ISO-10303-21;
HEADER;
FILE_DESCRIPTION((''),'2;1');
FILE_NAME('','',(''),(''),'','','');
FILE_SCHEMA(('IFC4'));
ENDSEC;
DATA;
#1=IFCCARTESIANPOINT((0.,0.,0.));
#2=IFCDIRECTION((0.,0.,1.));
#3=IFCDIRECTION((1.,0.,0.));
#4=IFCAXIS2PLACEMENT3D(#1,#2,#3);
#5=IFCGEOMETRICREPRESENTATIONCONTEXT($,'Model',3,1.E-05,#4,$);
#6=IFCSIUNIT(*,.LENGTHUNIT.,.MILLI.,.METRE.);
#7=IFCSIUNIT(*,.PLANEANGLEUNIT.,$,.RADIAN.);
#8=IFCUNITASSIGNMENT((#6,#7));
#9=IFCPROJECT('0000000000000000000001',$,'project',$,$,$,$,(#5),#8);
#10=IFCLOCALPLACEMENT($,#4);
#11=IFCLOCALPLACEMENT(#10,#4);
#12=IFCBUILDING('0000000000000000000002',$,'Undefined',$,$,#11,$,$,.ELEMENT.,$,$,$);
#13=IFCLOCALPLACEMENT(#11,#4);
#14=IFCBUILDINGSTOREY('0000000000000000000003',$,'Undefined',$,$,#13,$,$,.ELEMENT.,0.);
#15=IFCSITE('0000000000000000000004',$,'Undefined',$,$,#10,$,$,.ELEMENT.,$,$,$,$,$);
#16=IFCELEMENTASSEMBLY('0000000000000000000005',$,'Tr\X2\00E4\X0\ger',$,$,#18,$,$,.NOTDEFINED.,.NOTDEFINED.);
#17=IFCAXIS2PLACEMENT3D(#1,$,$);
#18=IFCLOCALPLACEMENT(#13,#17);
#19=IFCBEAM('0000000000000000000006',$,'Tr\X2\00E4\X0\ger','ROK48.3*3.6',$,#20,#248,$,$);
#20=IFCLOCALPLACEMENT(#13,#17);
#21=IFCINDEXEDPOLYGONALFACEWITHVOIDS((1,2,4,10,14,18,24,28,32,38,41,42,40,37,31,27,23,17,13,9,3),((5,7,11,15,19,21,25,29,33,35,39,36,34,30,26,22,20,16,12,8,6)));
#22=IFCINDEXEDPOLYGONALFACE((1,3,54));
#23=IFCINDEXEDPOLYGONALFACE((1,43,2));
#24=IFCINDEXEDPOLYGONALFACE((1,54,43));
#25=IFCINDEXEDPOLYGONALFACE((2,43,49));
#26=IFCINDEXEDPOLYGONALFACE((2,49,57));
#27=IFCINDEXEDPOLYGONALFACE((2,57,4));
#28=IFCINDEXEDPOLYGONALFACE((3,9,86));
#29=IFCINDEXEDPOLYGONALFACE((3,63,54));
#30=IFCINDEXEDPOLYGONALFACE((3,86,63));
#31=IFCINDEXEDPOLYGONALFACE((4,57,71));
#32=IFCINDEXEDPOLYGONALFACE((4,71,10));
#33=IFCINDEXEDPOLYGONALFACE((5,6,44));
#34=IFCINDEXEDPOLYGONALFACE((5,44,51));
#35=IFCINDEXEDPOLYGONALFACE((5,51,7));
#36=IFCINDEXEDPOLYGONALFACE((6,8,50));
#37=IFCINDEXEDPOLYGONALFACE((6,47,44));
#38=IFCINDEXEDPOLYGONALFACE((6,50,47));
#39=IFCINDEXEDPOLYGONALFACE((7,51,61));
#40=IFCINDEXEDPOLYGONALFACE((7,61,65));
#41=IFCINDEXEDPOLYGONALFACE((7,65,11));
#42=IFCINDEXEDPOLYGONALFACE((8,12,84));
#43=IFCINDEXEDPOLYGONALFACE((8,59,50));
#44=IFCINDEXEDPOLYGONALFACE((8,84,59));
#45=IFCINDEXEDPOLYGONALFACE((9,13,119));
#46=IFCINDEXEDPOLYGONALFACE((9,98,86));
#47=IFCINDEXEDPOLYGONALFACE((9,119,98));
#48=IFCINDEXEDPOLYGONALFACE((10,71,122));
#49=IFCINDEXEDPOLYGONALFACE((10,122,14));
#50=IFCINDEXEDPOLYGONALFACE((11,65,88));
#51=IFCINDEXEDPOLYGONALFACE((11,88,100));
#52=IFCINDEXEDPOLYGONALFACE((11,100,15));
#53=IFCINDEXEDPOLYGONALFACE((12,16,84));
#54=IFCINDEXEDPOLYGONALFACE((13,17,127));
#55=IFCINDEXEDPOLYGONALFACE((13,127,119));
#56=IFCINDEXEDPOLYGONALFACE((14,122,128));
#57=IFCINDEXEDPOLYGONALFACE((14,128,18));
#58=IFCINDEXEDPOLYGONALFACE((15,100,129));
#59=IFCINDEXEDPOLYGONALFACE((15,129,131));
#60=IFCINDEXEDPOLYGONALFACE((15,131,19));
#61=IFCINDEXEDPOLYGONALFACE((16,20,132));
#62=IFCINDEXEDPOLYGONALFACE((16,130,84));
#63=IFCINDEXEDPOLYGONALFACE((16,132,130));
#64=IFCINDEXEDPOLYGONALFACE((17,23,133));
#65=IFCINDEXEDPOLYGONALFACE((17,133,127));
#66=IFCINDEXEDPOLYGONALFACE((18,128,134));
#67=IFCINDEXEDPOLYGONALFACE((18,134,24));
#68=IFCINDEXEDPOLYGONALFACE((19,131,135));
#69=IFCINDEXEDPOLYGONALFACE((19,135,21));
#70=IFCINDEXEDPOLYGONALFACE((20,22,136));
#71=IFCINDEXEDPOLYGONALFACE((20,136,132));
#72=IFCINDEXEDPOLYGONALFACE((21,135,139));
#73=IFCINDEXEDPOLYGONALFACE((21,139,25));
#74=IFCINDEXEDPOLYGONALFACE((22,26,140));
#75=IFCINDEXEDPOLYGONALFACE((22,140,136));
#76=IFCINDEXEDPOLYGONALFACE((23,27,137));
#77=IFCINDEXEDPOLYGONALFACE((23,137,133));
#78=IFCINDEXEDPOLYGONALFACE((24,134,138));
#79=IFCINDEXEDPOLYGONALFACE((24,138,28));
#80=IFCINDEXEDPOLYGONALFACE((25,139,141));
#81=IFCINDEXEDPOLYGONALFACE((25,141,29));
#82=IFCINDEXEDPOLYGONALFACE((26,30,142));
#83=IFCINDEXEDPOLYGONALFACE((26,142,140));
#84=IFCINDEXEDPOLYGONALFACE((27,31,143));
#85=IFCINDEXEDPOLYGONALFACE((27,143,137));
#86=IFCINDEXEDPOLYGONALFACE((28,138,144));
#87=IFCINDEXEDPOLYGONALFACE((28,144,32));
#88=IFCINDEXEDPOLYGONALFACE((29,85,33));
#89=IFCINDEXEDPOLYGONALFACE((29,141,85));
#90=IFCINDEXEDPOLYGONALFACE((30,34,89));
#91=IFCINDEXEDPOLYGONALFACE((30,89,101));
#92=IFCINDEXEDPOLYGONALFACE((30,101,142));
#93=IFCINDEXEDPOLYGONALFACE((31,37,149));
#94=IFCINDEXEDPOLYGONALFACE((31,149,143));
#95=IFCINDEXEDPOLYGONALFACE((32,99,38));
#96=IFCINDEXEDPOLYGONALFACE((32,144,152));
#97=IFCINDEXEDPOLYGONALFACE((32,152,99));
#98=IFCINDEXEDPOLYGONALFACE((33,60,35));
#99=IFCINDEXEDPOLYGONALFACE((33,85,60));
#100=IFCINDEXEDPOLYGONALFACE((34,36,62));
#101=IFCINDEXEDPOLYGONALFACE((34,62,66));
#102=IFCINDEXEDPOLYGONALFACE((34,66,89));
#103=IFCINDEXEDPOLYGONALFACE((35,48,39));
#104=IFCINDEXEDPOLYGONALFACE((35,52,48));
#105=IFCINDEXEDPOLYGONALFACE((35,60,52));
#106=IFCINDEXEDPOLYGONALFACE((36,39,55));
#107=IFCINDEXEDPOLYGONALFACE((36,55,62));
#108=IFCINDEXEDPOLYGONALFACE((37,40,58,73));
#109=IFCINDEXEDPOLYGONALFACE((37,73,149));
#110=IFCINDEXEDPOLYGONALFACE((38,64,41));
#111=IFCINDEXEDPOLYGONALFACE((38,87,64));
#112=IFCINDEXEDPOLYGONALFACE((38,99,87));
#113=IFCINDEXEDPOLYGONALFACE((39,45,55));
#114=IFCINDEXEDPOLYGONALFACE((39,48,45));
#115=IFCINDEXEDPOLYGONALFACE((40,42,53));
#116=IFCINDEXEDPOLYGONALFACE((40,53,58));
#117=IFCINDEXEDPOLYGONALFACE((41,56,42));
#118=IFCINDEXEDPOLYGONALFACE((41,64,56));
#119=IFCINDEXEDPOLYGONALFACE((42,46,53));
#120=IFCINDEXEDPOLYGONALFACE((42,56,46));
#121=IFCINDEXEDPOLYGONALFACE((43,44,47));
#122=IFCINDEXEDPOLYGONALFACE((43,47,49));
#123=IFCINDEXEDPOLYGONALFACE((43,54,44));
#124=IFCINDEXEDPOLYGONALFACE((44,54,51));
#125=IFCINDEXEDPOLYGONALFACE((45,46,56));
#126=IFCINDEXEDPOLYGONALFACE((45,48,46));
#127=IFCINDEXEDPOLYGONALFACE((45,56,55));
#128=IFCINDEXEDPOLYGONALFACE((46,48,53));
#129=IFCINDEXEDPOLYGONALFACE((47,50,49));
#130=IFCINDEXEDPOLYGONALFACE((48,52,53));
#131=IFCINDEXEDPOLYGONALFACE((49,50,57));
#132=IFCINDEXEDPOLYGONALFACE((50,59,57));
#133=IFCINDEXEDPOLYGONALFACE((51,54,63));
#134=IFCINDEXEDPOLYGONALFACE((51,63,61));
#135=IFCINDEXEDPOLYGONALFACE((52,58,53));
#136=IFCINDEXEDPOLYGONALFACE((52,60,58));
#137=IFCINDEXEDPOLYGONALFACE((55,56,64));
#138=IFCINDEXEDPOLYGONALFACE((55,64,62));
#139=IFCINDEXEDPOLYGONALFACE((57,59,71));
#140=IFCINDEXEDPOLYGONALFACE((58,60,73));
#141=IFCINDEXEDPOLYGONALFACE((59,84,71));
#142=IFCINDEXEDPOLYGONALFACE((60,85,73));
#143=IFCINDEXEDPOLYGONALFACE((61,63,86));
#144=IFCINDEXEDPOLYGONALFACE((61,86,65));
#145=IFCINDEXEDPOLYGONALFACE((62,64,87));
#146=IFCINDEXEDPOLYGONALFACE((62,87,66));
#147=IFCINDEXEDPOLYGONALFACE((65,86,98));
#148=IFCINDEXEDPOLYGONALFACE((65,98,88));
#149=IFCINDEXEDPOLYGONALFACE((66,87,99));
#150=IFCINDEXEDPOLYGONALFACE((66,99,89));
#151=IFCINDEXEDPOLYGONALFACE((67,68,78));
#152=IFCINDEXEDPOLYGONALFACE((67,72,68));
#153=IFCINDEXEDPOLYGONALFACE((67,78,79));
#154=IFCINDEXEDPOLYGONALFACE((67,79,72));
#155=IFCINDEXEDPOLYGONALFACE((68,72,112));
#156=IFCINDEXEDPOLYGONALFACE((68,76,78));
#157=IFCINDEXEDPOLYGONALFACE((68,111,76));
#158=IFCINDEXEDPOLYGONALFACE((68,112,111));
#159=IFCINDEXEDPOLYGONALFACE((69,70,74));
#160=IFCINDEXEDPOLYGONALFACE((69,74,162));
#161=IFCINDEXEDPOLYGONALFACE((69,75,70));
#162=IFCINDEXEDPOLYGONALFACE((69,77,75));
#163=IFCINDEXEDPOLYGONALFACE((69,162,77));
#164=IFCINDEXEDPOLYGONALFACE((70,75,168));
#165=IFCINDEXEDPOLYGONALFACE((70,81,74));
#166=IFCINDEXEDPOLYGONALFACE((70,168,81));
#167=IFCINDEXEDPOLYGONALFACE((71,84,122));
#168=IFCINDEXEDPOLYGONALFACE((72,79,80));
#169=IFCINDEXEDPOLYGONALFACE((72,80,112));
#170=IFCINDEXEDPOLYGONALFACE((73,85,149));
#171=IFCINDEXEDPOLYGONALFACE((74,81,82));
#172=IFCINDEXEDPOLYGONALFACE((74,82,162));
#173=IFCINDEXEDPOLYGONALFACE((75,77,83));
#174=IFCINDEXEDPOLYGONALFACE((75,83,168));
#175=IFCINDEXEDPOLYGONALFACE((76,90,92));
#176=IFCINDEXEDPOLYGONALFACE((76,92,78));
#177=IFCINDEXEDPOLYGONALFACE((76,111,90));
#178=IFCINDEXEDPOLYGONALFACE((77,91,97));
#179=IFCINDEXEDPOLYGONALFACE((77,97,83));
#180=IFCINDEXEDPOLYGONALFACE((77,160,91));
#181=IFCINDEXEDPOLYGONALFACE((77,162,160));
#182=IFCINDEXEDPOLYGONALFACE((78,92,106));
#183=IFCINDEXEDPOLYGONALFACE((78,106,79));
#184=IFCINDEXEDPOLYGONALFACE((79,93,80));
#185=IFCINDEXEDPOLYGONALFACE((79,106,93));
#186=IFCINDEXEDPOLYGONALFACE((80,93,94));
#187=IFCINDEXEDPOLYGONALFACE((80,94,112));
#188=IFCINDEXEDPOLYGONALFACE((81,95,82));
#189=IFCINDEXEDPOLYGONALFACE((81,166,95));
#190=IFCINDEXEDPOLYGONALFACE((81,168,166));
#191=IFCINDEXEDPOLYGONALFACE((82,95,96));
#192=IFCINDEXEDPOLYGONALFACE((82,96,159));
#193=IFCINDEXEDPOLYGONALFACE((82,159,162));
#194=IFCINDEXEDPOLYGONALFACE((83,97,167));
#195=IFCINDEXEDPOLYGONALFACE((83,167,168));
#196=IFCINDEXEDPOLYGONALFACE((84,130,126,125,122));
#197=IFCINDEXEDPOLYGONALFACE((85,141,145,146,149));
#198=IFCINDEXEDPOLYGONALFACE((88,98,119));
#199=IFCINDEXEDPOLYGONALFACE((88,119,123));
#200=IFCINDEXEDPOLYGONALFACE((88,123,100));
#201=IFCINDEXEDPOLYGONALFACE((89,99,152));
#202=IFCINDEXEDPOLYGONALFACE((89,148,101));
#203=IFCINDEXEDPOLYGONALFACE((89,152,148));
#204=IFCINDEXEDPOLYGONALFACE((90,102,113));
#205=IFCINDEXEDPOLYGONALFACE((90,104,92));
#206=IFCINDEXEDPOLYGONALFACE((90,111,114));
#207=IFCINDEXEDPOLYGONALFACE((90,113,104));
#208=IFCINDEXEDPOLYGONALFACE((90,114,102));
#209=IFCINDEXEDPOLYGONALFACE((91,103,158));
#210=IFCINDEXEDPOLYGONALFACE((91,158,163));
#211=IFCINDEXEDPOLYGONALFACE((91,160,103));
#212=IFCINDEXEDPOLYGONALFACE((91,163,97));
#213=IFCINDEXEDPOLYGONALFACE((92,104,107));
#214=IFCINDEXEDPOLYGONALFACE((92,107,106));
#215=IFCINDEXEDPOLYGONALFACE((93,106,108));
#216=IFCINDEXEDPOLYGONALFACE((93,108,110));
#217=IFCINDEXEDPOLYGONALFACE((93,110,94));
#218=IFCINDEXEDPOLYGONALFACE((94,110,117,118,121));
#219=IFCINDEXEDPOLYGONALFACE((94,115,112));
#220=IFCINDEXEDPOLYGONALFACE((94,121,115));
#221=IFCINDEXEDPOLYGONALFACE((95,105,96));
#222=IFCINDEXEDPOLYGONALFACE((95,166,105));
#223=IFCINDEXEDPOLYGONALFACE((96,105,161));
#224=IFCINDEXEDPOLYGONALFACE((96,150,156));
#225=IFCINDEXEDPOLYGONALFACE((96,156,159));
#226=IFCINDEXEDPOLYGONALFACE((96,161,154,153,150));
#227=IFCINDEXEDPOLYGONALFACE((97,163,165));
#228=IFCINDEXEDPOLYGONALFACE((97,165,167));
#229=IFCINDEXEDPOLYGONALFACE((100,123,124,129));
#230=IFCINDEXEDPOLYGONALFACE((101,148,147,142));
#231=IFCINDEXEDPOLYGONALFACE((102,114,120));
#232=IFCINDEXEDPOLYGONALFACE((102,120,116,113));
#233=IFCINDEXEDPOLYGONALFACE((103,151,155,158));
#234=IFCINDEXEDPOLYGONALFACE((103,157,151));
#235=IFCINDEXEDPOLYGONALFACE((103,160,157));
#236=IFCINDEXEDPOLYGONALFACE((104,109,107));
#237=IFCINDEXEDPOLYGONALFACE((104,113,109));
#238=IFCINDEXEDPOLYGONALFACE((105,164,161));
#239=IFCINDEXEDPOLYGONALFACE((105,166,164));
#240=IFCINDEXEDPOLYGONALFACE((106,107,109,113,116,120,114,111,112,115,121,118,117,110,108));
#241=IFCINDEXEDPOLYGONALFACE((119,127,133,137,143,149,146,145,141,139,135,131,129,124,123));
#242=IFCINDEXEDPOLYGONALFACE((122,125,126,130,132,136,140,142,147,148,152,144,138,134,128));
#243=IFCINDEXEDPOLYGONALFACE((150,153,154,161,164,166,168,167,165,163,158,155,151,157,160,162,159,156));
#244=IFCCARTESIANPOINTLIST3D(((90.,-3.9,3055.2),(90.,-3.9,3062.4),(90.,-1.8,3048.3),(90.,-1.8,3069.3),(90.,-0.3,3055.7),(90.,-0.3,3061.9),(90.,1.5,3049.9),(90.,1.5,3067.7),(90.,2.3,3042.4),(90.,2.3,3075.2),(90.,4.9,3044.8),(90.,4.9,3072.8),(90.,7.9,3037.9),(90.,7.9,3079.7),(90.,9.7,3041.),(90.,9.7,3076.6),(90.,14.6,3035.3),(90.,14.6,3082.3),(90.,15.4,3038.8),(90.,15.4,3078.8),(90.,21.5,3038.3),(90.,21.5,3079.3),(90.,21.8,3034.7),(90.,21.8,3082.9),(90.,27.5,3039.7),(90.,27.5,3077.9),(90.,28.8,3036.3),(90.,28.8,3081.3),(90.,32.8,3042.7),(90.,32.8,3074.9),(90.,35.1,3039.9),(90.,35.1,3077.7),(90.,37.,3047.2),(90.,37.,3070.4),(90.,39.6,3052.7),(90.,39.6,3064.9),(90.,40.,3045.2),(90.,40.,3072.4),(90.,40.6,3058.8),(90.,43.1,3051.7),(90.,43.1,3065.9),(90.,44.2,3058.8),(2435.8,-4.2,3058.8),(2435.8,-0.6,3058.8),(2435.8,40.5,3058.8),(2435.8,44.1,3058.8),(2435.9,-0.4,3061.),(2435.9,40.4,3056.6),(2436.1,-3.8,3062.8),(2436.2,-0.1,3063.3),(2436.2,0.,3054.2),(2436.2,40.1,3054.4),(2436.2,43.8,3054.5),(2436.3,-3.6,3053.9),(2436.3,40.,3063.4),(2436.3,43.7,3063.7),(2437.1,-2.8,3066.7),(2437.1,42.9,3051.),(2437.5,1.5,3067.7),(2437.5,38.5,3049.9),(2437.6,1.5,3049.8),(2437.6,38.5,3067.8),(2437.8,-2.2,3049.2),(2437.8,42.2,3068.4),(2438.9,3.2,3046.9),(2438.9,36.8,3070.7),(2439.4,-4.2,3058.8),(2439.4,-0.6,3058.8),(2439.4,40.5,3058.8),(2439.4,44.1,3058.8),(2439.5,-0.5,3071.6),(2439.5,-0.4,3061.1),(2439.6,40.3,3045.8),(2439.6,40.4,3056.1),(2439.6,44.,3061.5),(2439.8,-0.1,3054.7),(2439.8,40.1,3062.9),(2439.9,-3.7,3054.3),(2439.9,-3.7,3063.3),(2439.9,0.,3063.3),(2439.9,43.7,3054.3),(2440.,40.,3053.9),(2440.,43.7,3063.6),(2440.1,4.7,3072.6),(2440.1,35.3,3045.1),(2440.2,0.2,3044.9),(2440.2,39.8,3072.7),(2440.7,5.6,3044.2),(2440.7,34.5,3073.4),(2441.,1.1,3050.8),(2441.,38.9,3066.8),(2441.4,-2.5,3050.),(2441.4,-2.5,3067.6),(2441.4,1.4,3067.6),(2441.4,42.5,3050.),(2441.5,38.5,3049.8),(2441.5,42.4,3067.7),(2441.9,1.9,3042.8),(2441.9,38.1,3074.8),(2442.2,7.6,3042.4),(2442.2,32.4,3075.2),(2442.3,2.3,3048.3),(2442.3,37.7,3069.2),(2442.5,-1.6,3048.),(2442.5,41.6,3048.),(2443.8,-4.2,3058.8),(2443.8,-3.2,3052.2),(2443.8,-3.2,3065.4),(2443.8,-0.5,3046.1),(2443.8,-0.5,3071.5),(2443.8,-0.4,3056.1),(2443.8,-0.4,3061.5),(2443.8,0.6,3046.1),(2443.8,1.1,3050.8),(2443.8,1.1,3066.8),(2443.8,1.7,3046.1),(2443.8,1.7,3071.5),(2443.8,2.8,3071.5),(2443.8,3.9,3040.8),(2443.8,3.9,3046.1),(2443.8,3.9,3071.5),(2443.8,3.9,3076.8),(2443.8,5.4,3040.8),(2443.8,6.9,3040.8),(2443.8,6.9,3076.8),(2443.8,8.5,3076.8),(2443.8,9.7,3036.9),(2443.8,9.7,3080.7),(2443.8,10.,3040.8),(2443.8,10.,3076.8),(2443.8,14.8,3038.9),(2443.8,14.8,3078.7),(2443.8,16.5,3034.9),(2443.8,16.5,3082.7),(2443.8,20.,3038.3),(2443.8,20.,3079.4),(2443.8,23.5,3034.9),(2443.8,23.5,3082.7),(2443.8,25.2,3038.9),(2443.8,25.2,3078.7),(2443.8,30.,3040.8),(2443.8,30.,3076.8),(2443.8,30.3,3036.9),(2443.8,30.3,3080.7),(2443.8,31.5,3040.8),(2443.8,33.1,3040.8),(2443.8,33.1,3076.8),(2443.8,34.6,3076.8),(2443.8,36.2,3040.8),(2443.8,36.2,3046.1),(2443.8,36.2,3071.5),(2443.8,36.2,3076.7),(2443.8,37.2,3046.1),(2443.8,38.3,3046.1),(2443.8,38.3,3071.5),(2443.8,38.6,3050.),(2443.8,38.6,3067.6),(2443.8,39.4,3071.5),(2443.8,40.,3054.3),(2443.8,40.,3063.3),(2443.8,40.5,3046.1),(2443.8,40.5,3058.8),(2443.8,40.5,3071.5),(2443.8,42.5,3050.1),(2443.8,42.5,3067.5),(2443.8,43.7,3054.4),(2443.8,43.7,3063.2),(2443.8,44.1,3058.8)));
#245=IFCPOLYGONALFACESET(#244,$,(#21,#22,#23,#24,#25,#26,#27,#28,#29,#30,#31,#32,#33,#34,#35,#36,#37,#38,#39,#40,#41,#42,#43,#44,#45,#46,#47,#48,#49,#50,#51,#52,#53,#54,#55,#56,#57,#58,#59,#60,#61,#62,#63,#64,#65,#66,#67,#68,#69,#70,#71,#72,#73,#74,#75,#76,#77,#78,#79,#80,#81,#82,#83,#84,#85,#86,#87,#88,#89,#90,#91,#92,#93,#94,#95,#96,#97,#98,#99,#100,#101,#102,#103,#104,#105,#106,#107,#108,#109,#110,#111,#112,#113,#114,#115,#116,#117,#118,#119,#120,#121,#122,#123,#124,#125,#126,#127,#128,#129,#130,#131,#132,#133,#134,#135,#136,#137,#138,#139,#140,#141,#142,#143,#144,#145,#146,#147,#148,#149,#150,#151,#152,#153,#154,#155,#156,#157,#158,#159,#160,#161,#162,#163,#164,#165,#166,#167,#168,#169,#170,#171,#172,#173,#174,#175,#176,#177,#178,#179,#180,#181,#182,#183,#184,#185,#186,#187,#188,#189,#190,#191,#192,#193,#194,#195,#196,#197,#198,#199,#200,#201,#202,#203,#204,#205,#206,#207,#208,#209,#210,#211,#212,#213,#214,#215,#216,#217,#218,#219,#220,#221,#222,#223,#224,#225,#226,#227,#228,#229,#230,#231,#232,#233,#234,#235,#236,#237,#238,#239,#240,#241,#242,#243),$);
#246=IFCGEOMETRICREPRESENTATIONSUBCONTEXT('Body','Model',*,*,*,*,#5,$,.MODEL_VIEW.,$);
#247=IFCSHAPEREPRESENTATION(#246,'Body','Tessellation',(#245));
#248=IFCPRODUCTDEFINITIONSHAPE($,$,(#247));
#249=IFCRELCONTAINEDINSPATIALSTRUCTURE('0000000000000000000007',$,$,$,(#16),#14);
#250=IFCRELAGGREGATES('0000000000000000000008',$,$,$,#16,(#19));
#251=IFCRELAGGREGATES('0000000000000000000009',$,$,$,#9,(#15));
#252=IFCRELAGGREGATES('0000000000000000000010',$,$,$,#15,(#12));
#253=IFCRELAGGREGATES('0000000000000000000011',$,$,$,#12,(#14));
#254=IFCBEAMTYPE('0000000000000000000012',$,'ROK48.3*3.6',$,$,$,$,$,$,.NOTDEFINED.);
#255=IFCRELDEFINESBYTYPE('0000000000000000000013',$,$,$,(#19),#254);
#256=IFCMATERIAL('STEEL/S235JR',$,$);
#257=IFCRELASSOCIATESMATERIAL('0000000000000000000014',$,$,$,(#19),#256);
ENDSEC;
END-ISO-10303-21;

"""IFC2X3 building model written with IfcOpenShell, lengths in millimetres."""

from ifc_helpers import new_model, si_unit, frame, origin_with_axes, origin_2d_with_axis, place, context, subcontext, project, spatial, hollow_circle, extrude, boolean, material, type_object, element, aggregate, save


model = new_model("IFC2X3")

# Units and contexts
model_context = context("Model", 3, precision=1e-05, world=origin_with_axes())
body_context = subcontext(model_context, "Body", "Model", "MODEL_VIEW")
ifc_project = project(units=[si_unit("LENGTHUNIT", "METRE", prefix="MILLI"), si_unit("PLANEANGLEUNIT", "RADIAN")], contexts=[model_context])

# Site, building, storey
site_placement = place(None, origin_with_axes())
site = spatial("IfcSite", under=ifc_project, at=site_placement, Name="Undefined", CompositionType="ELEMENT")
building_placement = place(site_placement, origin_with_axes())
building = spatial("IfcBuilding", under=site, at=building_placement, Name="Undefined", CompositionType="ELEMENT")
storey_placement = place(building_placement, origin_with_axes())
storey = spatial("IfcBuildingStorey", under=building, at=storey_placement, Name="Undefined", CompositionType="ELEMENT", Elevation=0.0)

# Shared definitions
ifc_material = material(Name="STEEL/S235JR")
beam_type = type_object("IfcBeamType", Name="ROK48.3*3.6", PredefinedType="NOTDEFINED")

# Element assembly, beam
assembly_1_placement = place(storey_placement, origin_with_axes())
assembly_1 = element("IfcElementAssembly", 1, at=assembly_1_placement, inside=storey, Name="Träger", AssemblyPlace="NOTDEFINED", PredefinedType="NOTDEFINED")
beam_1_placement = place(assembly_1_placement, frame((2443.8, 20.0, 3058.8), z_axis=(0.0, 0.0, 1.0), x_axis=(-1.0, 0.0, 0.0)))
beam_1 = element("IfcBeam", 2, at=beam_1_placement, type_object=beam_type, material=ifc_material, Name="Träger", Description="ROK48.3*3.6", context=body_context, shape_type="CSG", body=[
    boolean("DIFFERENCE", extrude(hollow_circle(Radius=24.1, WallThickness=3.6, at=origin_2d_with_axis()), frame((2353.8, 0.0, 0.0), z_axis=(-1.0, 0.0, 0.0), x_axis=(0.0, -1.0, 0.0)), (0.0, 0.0, 1.0), 2353.8), extrude(hollow_circle(Radius=24.1, WallThickness=3.6, at=origin_2d_with_axis()), frame((-16.2, -90.0, 0.0), z_axis=(0.000346, 1.0, -0.000024), x_axis=(1.0, -0.000346, 0.0)), (0.0, 0.0, 1.0), 146.2)),
])

aggregate(assembly_1, [beam_1])

save(model, "model.ifc")
